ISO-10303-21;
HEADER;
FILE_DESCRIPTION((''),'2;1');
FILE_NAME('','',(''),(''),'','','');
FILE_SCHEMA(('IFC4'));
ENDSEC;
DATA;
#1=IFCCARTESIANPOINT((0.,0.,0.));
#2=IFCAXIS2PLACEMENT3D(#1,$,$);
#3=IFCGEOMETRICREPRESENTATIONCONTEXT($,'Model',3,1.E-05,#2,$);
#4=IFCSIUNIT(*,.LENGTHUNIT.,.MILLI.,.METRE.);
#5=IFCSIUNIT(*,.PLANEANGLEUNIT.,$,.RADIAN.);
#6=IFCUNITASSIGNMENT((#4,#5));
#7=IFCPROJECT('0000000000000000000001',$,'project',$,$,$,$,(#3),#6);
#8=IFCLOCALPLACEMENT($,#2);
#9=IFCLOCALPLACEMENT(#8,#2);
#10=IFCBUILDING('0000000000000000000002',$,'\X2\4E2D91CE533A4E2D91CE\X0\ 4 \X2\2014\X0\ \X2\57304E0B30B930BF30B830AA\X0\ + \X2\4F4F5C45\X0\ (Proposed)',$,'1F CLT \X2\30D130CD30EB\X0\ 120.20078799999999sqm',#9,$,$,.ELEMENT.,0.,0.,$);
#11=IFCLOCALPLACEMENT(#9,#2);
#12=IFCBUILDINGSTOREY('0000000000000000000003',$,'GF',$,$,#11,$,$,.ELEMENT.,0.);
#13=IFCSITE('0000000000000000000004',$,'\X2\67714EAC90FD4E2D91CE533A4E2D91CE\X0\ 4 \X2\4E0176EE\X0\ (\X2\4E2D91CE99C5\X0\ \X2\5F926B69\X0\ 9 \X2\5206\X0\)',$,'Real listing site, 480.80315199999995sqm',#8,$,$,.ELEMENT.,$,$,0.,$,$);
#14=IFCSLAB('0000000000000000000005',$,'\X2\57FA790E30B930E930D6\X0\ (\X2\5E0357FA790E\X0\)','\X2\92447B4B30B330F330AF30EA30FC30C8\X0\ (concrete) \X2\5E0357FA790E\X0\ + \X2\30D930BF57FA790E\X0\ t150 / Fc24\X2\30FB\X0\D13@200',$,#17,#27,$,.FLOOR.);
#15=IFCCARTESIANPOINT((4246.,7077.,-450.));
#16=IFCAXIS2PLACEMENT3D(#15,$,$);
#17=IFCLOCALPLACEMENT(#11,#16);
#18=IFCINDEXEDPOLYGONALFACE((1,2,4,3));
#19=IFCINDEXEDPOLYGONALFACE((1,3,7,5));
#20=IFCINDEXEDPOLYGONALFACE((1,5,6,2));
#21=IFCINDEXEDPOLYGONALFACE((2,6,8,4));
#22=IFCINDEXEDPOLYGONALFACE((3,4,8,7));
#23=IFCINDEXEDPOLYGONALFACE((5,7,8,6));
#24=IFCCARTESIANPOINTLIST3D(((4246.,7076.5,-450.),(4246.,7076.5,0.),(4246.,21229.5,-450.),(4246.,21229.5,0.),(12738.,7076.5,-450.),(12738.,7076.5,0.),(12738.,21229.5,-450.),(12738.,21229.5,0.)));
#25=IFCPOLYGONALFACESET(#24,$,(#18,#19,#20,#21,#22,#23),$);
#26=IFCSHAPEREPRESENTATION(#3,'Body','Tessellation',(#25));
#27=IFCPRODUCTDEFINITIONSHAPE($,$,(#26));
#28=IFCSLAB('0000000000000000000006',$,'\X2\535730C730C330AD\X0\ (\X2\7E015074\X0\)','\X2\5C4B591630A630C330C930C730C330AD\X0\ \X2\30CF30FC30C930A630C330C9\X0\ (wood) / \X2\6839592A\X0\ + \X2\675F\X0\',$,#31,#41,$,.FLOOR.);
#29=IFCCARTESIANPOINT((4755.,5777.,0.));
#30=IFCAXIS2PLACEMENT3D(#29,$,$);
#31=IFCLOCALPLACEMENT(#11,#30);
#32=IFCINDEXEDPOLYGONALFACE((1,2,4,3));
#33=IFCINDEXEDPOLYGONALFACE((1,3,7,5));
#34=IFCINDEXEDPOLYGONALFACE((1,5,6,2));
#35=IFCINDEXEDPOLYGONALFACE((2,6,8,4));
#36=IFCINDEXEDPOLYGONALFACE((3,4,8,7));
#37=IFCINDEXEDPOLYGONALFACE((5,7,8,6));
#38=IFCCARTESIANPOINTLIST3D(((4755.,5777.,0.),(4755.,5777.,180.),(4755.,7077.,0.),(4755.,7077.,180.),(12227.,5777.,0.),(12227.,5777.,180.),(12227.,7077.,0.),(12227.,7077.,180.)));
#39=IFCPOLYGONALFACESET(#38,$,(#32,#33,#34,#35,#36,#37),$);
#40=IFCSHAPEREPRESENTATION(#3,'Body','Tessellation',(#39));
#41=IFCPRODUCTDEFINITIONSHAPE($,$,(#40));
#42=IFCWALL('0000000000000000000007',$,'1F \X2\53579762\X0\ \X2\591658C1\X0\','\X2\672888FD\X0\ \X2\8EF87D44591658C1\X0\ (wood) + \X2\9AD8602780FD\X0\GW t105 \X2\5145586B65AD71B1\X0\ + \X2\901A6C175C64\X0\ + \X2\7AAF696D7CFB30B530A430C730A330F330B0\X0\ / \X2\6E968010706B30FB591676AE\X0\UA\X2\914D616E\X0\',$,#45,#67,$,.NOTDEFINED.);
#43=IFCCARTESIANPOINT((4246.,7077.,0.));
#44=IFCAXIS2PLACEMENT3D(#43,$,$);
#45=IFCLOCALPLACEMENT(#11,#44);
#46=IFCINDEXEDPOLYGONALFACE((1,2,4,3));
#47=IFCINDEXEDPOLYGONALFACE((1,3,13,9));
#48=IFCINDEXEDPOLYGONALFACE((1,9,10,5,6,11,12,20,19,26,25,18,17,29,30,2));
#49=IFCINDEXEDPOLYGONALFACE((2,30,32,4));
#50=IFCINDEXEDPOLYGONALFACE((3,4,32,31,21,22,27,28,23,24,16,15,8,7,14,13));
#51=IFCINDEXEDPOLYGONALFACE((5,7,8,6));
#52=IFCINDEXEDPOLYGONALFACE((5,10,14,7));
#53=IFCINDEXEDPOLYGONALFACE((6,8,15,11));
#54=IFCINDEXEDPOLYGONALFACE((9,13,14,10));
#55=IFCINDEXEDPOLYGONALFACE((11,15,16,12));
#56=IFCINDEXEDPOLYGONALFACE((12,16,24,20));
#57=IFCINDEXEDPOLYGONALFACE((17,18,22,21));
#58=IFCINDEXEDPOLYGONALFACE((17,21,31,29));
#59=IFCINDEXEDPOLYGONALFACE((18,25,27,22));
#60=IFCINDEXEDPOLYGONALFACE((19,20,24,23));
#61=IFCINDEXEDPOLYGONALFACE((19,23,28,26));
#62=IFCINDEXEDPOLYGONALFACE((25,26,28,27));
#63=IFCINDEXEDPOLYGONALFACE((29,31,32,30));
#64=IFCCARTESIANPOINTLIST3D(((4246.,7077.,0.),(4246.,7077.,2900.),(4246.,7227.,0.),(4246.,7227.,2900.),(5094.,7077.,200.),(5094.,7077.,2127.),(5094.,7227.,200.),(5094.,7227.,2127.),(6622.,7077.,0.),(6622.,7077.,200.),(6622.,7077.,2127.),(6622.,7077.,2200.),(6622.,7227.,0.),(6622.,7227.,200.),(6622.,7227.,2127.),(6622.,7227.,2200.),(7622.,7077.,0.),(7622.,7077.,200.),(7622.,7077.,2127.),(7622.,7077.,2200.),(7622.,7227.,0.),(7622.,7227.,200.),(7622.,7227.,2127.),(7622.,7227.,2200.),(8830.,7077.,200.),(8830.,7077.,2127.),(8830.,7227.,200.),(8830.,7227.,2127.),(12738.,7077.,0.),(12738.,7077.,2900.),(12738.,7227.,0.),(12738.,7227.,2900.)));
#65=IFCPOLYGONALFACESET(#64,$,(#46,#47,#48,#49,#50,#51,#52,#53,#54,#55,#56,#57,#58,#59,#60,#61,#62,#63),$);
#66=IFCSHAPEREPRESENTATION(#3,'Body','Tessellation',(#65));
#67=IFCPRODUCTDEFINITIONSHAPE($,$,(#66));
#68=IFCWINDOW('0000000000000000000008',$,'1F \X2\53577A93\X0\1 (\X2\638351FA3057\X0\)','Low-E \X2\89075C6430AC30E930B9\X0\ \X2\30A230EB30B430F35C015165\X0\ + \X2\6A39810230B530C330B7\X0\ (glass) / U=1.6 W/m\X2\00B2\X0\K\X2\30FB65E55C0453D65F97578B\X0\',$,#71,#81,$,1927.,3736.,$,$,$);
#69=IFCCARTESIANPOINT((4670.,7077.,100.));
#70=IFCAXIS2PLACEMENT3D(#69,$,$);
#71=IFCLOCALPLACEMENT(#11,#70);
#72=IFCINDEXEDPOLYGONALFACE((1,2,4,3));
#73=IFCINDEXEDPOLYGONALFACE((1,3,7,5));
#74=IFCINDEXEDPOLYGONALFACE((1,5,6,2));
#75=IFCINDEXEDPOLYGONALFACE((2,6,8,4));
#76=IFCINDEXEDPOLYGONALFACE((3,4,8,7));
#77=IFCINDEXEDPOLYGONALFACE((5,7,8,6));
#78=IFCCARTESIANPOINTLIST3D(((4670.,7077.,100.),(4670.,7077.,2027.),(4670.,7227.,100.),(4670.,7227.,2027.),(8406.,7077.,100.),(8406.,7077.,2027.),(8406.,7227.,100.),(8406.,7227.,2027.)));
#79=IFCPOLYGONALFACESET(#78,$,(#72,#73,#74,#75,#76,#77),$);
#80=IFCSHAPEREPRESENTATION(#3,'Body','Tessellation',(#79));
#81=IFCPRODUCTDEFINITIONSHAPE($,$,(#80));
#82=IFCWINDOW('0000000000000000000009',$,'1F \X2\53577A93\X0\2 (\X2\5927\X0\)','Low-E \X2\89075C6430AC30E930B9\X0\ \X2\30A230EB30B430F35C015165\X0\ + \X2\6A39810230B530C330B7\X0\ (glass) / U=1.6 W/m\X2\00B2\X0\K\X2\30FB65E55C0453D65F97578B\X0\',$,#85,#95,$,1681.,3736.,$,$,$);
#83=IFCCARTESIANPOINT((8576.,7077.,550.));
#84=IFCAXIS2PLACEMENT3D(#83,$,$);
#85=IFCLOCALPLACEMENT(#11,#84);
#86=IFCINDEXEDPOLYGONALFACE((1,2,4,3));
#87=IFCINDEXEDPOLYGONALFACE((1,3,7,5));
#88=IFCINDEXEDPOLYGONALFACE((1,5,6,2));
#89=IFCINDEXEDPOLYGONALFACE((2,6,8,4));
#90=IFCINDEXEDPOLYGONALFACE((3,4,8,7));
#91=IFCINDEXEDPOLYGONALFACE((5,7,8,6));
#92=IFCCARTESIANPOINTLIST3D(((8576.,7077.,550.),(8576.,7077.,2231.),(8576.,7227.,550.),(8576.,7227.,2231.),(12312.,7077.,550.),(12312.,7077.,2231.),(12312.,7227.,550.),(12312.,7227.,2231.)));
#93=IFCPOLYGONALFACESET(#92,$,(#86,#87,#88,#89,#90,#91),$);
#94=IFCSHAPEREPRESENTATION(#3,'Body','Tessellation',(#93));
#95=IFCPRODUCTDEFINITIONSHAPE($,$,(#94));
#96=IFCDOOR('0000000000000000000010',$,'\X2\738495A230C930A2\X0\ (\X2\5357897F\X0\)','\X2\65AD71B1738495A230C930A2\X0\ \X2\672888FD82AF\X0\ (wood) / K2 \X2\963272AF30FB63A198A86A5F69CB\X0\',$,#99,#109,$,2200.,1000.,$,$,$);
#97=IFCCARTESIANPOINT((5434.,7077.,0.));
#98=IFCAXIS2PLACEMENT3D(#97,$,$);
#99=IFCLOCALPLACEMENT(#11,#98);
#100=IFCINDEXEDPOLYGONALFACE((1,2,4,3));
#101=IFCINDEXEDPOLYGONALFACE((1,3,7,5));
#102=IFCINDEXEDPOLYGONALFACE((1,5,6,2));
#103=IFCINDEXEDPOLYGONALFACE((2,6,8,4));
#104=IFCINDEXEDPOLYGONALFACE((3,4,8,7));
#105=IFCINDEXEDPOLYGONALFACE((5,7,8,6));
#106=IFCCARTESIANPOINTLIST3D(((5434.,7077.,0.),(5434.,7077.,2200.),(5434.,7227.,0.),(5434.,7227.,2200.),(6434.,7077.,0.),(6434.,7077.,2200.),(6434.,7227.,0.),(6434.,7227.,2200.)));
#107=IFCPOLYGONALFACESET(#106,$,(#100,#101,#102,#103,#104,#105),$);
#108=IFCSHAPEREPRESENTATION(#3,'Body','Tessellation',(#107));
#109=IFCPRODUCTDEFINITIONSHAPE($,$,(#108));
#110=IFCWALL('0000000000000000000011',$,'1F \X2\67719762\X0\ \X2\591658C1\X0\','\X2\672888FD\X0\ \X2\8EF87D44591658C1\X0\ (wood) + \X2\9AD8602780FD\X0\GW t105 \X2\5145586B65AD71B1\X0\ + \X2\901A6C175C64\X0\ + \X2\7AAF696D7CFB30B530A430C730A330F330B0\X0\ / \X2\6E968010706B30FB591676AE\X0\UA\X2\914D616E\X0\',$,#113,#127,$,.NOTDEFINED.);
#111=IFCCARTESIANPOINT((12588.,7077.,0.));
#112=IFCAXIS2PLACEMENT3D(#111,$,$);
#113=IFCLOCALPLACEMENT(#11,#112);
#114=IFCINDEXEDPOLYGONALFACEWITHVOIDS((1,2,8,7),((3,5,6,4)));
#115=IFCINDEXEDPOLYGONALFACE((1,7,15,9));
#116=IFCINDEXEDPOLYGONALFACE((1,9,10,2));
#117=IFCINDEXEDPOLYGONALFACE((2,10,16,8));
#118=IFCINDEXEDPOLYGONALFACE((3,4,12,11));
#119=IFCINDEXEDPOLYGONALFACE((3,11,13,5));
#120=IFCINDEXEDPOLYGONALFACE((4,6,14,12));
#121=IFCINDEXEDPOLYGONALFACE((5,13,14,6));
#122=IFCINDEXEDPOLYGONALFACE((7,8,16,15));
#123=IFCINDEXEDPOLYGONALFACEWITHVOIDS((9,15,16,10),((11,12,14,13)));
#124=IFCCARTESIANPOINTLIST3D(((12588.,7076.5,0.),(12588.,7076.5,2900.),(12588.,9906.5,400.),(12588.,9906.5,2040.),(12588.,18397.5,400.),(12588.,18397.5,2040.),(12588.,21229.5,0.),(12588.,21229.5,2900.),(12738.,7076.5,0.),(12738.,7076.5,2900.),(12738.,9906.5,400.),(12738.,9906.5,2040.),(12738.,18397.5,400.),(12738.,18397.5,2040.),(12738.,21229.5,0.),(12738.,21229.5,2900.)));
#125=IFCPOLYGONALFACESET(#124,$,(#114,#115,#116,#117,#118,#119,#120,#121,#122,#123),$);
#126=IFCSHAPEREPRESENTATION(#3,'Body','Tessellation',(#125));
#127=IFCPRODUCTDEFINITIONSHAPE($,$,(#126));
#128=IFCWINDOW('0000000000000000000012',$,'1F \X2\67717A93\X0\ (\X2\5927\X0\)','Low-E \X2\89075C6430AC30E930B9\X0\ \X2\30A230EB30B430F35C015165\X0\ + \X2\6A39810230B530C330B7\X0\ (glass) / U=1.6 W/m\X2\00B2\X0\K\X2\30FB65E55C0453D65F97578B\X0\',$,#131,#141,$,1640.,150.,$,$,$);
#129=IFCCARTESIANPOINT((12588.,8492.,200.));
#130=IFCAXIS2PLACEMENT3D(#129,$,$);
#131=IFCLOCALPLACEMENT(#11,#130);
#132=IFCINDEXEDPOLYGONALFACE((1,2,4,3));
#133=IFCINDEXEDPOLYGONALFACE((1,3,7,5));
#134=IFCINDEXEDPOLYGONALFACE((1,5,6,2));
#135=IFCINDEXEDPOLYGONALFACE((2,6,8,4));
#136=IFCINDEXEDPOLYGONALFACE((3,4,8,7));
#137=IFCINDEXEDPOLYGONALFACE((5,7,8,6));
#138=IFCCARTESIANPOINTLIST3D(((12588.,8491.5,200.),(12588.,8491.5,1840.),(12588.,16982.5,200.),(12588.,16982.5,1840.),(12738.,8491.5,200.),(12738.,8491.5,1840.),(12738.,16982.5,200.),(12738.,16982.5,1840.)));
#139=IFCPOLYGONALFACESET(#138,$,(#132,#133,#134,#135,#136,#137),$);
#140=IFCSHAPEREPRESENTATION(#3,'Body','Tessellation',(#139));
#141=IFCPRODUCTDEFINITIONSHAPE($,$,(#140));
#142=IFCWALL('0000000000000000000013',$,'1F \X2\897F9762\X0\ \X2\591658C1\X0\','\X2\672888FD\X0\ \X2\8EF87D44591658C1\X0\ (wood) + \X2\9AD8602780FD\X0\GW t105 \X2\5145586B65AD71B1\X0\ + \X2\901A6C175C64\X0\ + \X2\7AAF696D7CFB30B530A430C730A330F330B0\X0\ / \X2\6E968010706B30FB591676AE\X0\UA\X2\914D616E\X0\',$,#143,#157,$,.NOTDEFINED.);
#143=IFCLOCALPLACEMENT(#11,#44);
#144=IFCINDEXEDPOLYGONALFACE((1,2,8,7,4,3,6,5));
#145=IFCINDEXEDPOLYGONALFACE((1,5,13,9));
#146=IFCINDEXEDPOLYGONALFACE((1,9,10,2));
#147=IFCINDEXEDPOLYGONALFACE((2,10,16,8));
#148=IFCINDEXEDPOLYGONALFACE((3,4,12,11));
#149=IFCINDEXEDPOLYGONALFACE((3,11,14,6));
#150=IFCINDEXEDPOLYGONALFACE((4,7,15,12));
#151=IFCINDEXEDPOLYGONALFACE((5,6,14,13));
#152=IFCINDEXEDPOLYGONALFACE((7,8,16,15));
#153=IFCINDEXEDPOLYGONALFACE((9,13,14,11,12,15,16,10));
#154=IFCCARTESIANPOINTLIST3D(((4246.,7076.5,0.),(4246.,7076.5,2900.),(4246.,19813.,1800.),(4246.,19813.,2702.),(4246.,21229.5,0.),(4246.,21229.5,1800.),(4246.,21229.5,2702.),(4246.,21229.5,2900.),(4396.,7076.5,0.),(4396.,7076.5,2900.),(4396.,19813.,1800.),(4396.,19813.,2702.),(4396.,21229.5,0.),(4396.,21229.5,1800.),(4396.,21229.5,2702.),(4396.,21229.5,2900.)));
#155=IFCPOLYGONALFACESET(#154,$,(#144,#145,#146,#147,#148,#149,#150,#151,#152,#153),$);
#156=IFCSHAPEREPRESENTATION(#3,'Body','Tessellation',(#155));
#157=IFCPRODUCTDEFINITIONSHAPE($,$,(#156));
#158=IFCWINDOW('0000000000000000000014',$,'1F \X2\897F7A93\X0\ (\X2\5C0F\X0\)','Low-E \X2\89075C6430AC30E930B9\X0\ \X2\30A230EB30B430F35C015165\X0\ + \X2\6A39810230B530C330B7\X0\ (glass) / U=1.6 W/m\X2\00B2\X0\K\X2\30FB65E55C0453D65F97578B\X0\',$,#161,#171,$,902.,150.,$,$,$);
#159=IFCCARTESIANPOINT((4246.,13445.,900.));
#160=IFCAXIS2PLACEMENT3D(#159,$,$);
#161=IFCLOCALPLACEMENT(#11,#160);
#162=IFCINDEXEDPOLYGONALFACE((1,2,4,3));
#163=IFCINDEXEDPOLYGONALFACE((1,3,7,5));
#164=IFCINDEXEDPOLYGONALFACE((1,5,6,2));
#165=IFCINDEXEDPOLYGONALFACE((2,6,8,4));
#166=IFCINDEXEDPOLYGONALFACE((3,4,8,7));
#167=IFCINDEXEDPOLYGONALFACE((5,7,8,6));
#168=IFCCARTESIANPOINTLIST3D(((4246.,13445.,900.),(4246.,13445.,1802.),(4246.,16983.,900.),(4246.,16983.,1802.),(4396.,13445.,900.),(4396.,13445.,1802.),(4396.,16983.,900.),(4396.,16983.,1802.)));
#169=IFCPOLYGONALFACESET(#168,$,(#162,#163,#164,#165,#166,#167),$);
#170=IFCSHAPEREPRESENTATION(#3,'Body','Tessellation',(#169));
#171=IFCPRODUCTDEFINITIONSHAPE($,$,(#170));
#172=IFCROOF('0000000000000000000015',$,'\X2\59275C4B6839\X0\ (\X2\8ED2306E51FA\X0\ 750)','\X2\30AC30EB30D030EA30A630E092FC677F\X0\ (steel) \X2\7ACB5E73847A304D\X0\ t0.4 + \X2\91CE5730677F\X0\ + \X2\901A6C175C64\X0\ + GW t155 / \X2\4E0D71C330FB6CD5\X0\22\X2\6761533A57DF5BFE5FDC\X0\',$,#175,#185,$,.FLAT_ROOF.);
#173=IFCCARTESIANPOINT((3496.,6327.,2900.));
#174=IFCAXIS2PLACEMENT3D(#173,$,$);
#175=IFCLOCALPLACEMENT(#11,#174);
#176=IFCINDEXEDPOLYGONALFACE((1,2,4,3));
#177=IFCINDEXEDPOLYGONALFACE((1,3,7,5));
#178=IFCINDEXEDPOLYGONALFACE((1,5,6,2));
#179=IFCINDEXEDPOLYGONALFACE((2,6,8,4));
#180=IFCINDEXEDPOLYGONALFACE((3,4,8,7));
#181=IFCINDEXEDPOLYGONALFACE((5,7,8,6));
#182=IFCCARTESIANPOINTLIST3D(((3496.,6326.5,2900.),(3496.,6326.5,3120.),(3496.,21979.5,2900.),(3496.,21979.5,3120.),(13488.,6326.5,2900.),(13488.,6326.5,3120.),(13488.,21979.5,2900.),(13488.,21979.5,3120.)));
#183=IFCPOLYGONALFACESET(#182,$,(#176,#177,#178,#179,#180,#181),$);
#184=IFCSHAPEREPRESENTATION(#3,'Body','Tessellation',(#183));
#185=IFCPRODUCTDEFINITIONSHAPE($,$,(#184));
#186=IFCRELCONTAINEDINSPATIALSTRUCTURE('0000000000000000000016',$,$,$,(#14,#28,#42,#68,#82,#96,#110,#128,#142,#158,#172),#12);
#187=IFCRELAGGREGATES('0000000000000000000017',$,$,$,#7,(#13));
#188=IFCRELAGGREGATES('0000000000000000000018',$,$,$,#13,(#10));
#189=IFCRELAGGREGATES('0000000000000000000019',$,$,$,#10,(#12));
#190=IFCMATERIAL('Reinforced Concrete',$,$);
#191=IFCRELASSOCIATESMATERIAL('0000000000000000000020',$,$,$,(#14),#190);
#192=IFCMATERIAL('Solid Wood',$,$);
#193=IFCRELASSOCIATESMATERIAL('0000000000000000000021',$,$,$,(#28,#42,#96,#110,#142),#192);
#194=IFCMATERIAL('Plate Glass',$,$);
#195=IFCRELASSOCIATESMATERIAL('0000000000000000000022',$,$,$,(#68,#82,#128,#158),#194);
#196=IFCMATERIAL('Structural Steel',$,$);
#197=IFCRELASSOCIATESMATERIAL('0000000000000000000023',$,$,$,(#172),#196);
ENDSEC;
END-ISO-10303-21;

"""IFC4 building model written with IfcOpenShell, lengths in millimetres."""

from ifc_helpers import new_model, si_unit, frame, frame_2d, origin, place, context, project, spatial, rectangle, extrude, material, element, fill, save


model = new_model("IFC4")

# Units and contexts
model_context = context("Model", 3, precision=1e-05, world=origin())
ifc_project = project(units=[si_unit("LENGTHUNIT", "METRE", prefix="MILLI"), si_unit("PLANEANGLEUNIT", "RADIAN")], contexts=[model_context])

# Site, building, storey
site_placement = place(None, origin())
site = spatial("IfcSite", under=ifc_project, at=site_placement, Name="東京都中野区中野 4 丁目 (中野駅 徒歩 9 分)", ObjectType="Real listing site, 480.80315199999995sqm", CompositionType="ELEMENT", RefElevation=0.0)
building_placement = place(site_placement, origin())
building = spatial("IfcBuilding", under=site, at=building_placement, Name="中野区中野 4 — 地下スタジオ + 住居 (Proposed)", ObjectType="1F CLT パネル 120.20078799999999sqm", CompositionType="ELEMENT", ElevationOfRefHeight=0.0, ElevationOfTerrain=0.0)
storey_placement = place(building_placement, origin())
storey = spatial("IfcBuildingStorey", under=building, at=storey_placement, Name="GF", CompositionType="ELEMENT", Elevation=0.0)

# Slabs
ifc_material_1 = material(Name="Reinforced Concrete")
slab_1_placement = place(storey_placement, frame((4246.0, 7077.0, -450.0)))
element("IfcSlab", 1, at=slab_1_placement, inside=storey, material=ifc_material_1, Name="基礎スラブ (布基礎)", Description="鉄筋コンクリート (concrete) 布基礎 + ベタ基礎 t150 / Fc24・D13@200", PredefinedType="FLOOR", context=model_context, shape_type="SweptSolid", body=[
    extrude(rectangle(XDim=8492.0, YDim=14153.0, at=frame_2d((4246.0, 7076.0))), frame((4246.0, 7077.0, -450.0)), (0.0, 0.0, 1.0), 450.0),
])
ifc_material_2 = material(Name="Solid Wood")
slab_2_placement = place(storey_placement, frame((4755.0, 5777.0, 0.0)))
element("IfcSlab", 2, at=slab_2_placement, inside=storey, material=ifc_material_2, Name="南デッキ (縁側)", Description="屋外ウッドデッキ ハードウッド (wood) / 根太 + 束", PredefinedType="FLOOR", context=model_context, shape_type="SweptSolid", body=[
    extrude(rectangle(XDim=7472.0, YDim=1300.0, at=frame_2d((3736.0, 650.0))), frame((4755.0, 5777.0, 0.0)), (0.0, 0.0, 1.0), 180.0),
])

# Wall, openings, windows, door
wall_1_placement = place(storey_placement, frame((4246.0, 7077.0, 0.0)))
wall_1 = element("IfcWall", 3, at=wall_1_placement, inside=storey, material=ifc_material_2, Name="1F 南面 外壁", Description="木製 軸組外壁 (wood) + 高性能GW t105 充填断熱 + 通気層 + 窯業系サイディング / 準耐火・外皮UA配慮", PredefinedType="NOTDEFINED", context=model_context, shape_type="SweptSolid", body=[
    extrude(rectangle(XDim=8492.0, YDim=150.0, at=frame_2d((4246.0, 75.0))), frame((4246.0, 7077.0, 0.0)), (0.0, 0.0, 1.0), 2900.0),
])
opening_1_placement = place(storey_placement, frame((4670.0, 7077.0, 100.0)))
opening_1 = element("IfcOpeningElement", 4, at=opening_1_placement, cuts=wall_1, PredefinedType="NOTDEFINED", context=model_context, shape_type="SweptSolid", body=[
    extrude(rectangle(XDim=3736.0, YDim=150.0, at=frame_2d((1868.0, 75.0))), frame((4670.0, 7077.0, 100.0)), (0.0, 0.0, 1.0), 1927.0),
])
opening_2_placement = place(storey_placement, frame((8576.0, 7077.0, 550.0)))
opening_2 = element("IfcOpeningElement", 5, at=opening_2_placement, cuts=wall_1, PredefinedType="NOTDEFINED", context=model_context, shape_type="SweptSolid", body=[
    extrude(rectangle(XDim=3736.0, YDim=150.0, at=frame_2d((1868.0, 75.0))), frame((8576.0, 7077.0, 550.0)), (0.0, 0.0, 1.0), 1681.0),
])
opening_3_placement = place(storey_placement, frame((5434.0, 7077.0, 0.0)))
opening_3 = element("IfcOpeningElement", 6, at=opening_3_placement, cuts=wall_1, PredefinedType="NOTDEFINED", context=model_context, shape_type="SweptSolid", body=[
    extrude(rectangle(XDim=1000.0, YDim=150.0, at=frame_2d((500.0, 75.0))), frame((5434.0, 7077.0, 0.0)), (0.0, 0.0, 1.0), 2200.0),
])
ifc_material_3 = material(Name="Plate Glass")
window_1_placement = place(storey_placement, frame((4670.0, 7077.0, 100.0)))
window_1 = element("IfcWindow", 7, at=window_1_placement, inside=storey, material=ifc_material_3, Name="1F 南窓1 (掃出し)", Description="Low-E 複層ガラス アルゴン封入 + 樹脂サッシ (glass) / U=1.6 W/m²K・日射取得型", OverallHeight=1927.0, OverallWidth=3736.0, context=model_context, shape_type="SweptSolid", body=[
    extrude(rectangle(XDim=3736.0, YDim=150.0, at=frame_2d((1868.0, 75.0))), frame((4670.0, 7077.0, 100.0)), (0.0, 0.0, 1.0), 1927.0),
])
fill(opening_1, window_1)
window_2_placement = place(storey_placement, frame((8576.0, 7077.0, 550.0)))
window_2 = element("IfcWindow", 8, at=window_2_placement, inside=storey, material=ifc_material_3, Name="1F 南窓2 (大)", Description="Low-E 複層ガラス アルゴン封入 + 樹脂サッシ (glass) / U=1.6 W/m²K・日射取得型", OverallHeight=1681.0, OverallWidth=3736.0, context=model_context, shape_type="SweptSolid", body=[
    extrude(rectangle(XDim=3736.0, YDim=150.0, at=frame_2d((1868.0, 75.0))), frame((8576.0, 7077.0, 550.0)), (0.0, 0.0, 1.0), 1681.0),
])
fill(opening_2, window_2)
door_placement = place(storey_placement, frame((5434.0, 7077.0, 0.0)))
door = element("IfcDoor", 9, at=door_placement, inside=storey, material=ifc_material_2, Name="玄関ドア (南西)", Description="断熱玄関ドア 木製芯 (wood) / K2 防犯・採風機構", OverallHeight=2200.0, OverallWidth=1000.0, context=model_context, shape_type="SweptSolid", body=[
    extrude(rectangle(XDim=1000.0, YDim=150.0, at=frame_2d((500.0, 75.0))), frame((5434.0, 7077.0, 0.0)), (0.0, 0.0, 1.0), 2200.0),
])
fill(opening_3, door)

# Walls, openings, windows
wall_2_placement = place(storey_placement, frame((12588.0, 7077.0, 0.0)))
wall_2 = element("IfcWall", 10, at=wall_2_placement, inside=storey, material=ifc_material_2, Name="1F 東面 外壁", Description="木製 軸組外壁 (wood) + 高性能GW t105 充填断熱 + 通気層 + 窯業系サイディング / 準耐火・外皮UA配慮", PredefinedType="NOTDEFINED", context=model_context, shape_type="SweptSolid", body=[
    extrude(rectangle(XDim=150.0, YDim=14153.0, at=frame_2d((75.0, 7076.0))), frame((12588.0, 7077.0, 0.0)), (0.0, 0.0, 1.0), 2900.0),
])
opening_4_placement = place(storey_placement, frame((12588.0, 8492.0, 200.0)))
opening_4 = element("IfcOpeningElement", 11, at=opening_4_placement, cuts=wall_2, PredefinedType="NOTDEFINED", context=model_context, shape_type="SweptSolid", body=[
    extrude(rectangle(XDim=150.0, YDim=8491.0, at=frame_2d((75.0, 4245.0))), frame((12588.0, 8492.0, 200.0)), (0.0, 0.0, 1.0), 1640.0),
])
window_3_placement = place(storey_placement, frame((12588.0, 8492.0, 200.0)))
window_3 = element("IfcWindow", 12, at=window_3_placement, inside=storey, material=ifc_material_3, Name="1F 東窓 (大)", Description="Low-E 複層ガラス アルゴン封入 + 樹脂サッシ (glass) / U=1.6 W/m²K・日射取得型", OverallHeight=1640.0, OverallWidth=150.0, context=model_context, shape_type="SweptSolid", body=[
    extrude(rectangle(XDim=150.0, YDim=8491.0, at=frame_2d((75.0, 4245.0))), frame((12588.0, 8492.0, 200.0)), (0.0, 0.0, 1.0), 1640.0),
])
fill(opening_4, window_3)
wall_3_placement = place(storey_placement, frame((4246.0, 7077.0, 0.0)))
wall_3 = element("IfcWall", 13, at=wall_3_placement, inside=storey, material=ifc_material_2, Name="1F 西面 外壁", Description="木製 軸組外壁 (wood) + 高性能GW t105 充填断熱 + 通気層 + 窯業系サイディング / 準耐火・外皮UA配慮", PredefinedType="NOTDEFINED", context=model_context, shape_type="SweptSolid", body=[
    extrude(rectangle(XDim=150.0, YDim=14153.0, at=frame_2d((75.0, 7076.0))), frame((4246.0, 7077.0, 0.0)), (0.0, 0.0, 1.0), 2900.0),
])
opening_5_placement = place(storey_placement, frame((4246.0, 13445.0, 900.0)))
opening_5 = element("IfcOpeningElement", 14, at=opening_5_placement, cuts=wall_3, PredefinedType="NOTDEFINED", context=model_context, shape_type="SweptSolid", body=[
    extrude(rectangle(XDim=150.0, YDim=3538.0, at=frame_2d((75.0, 1769.0))), frame((4246.0, 13445.0, 900.0)), (0.0, 0.0, 1.0), 902.0),
])
window_4_placement = place(storey_placement, frame((4246.0, 13445.0, 900.0)))
window_4 = element("IfcWindow", 15, at=window_4_placement, inside=storey, material=ifc_material_3, Name="1F 西窓 (小)", Description="Low-E 複層ガラス アルゴン封入 + 樹脂サッシ (glass) / U=1.6 W/m²K・日射取得型", OverallHeight=902.0, OverallWidth=150.0, context=model_context, shape_type="SweptSolid", body=[
    extrude(rectangle(XDim=150.0, YDim=3538.0, at=frame_2d((75.0, 1769.0))), frame((4246.0, 13445.0, 900.0)), (0.0, 0.0, 1.0), 902.0),
])
fill(opening_5, window_4)

# Roof
ifc_material_4 = material(Name="Structural Steel")
roof_placement = place(storey_placement, frame((3496.0, 6327.0, 2900.0)))
element("IfcRoof", 16, at=roof_placement, inside=storey, material=ifc_material_4, Name="大屋根 (軒の出 750)", Description="ガルバリウム鋼板 (steel) 立平葺き t0.4 + 野地板 + 通気層 + GW t155 / 不燃・法22条区域対応", PredefinedType="FLAT_ROOF", context=model_context, shape_type="SweptSolid", body=[
    extrude(rectangle(XDim=9992.0, YDim=15653.0, at=frame_2d((4996.0, 7826.0))), frame((3496.0, 6327.0, 2900.0)), (0.0, 0.0, 1.0), 220.0),
])

save(model, "model.ifc")
